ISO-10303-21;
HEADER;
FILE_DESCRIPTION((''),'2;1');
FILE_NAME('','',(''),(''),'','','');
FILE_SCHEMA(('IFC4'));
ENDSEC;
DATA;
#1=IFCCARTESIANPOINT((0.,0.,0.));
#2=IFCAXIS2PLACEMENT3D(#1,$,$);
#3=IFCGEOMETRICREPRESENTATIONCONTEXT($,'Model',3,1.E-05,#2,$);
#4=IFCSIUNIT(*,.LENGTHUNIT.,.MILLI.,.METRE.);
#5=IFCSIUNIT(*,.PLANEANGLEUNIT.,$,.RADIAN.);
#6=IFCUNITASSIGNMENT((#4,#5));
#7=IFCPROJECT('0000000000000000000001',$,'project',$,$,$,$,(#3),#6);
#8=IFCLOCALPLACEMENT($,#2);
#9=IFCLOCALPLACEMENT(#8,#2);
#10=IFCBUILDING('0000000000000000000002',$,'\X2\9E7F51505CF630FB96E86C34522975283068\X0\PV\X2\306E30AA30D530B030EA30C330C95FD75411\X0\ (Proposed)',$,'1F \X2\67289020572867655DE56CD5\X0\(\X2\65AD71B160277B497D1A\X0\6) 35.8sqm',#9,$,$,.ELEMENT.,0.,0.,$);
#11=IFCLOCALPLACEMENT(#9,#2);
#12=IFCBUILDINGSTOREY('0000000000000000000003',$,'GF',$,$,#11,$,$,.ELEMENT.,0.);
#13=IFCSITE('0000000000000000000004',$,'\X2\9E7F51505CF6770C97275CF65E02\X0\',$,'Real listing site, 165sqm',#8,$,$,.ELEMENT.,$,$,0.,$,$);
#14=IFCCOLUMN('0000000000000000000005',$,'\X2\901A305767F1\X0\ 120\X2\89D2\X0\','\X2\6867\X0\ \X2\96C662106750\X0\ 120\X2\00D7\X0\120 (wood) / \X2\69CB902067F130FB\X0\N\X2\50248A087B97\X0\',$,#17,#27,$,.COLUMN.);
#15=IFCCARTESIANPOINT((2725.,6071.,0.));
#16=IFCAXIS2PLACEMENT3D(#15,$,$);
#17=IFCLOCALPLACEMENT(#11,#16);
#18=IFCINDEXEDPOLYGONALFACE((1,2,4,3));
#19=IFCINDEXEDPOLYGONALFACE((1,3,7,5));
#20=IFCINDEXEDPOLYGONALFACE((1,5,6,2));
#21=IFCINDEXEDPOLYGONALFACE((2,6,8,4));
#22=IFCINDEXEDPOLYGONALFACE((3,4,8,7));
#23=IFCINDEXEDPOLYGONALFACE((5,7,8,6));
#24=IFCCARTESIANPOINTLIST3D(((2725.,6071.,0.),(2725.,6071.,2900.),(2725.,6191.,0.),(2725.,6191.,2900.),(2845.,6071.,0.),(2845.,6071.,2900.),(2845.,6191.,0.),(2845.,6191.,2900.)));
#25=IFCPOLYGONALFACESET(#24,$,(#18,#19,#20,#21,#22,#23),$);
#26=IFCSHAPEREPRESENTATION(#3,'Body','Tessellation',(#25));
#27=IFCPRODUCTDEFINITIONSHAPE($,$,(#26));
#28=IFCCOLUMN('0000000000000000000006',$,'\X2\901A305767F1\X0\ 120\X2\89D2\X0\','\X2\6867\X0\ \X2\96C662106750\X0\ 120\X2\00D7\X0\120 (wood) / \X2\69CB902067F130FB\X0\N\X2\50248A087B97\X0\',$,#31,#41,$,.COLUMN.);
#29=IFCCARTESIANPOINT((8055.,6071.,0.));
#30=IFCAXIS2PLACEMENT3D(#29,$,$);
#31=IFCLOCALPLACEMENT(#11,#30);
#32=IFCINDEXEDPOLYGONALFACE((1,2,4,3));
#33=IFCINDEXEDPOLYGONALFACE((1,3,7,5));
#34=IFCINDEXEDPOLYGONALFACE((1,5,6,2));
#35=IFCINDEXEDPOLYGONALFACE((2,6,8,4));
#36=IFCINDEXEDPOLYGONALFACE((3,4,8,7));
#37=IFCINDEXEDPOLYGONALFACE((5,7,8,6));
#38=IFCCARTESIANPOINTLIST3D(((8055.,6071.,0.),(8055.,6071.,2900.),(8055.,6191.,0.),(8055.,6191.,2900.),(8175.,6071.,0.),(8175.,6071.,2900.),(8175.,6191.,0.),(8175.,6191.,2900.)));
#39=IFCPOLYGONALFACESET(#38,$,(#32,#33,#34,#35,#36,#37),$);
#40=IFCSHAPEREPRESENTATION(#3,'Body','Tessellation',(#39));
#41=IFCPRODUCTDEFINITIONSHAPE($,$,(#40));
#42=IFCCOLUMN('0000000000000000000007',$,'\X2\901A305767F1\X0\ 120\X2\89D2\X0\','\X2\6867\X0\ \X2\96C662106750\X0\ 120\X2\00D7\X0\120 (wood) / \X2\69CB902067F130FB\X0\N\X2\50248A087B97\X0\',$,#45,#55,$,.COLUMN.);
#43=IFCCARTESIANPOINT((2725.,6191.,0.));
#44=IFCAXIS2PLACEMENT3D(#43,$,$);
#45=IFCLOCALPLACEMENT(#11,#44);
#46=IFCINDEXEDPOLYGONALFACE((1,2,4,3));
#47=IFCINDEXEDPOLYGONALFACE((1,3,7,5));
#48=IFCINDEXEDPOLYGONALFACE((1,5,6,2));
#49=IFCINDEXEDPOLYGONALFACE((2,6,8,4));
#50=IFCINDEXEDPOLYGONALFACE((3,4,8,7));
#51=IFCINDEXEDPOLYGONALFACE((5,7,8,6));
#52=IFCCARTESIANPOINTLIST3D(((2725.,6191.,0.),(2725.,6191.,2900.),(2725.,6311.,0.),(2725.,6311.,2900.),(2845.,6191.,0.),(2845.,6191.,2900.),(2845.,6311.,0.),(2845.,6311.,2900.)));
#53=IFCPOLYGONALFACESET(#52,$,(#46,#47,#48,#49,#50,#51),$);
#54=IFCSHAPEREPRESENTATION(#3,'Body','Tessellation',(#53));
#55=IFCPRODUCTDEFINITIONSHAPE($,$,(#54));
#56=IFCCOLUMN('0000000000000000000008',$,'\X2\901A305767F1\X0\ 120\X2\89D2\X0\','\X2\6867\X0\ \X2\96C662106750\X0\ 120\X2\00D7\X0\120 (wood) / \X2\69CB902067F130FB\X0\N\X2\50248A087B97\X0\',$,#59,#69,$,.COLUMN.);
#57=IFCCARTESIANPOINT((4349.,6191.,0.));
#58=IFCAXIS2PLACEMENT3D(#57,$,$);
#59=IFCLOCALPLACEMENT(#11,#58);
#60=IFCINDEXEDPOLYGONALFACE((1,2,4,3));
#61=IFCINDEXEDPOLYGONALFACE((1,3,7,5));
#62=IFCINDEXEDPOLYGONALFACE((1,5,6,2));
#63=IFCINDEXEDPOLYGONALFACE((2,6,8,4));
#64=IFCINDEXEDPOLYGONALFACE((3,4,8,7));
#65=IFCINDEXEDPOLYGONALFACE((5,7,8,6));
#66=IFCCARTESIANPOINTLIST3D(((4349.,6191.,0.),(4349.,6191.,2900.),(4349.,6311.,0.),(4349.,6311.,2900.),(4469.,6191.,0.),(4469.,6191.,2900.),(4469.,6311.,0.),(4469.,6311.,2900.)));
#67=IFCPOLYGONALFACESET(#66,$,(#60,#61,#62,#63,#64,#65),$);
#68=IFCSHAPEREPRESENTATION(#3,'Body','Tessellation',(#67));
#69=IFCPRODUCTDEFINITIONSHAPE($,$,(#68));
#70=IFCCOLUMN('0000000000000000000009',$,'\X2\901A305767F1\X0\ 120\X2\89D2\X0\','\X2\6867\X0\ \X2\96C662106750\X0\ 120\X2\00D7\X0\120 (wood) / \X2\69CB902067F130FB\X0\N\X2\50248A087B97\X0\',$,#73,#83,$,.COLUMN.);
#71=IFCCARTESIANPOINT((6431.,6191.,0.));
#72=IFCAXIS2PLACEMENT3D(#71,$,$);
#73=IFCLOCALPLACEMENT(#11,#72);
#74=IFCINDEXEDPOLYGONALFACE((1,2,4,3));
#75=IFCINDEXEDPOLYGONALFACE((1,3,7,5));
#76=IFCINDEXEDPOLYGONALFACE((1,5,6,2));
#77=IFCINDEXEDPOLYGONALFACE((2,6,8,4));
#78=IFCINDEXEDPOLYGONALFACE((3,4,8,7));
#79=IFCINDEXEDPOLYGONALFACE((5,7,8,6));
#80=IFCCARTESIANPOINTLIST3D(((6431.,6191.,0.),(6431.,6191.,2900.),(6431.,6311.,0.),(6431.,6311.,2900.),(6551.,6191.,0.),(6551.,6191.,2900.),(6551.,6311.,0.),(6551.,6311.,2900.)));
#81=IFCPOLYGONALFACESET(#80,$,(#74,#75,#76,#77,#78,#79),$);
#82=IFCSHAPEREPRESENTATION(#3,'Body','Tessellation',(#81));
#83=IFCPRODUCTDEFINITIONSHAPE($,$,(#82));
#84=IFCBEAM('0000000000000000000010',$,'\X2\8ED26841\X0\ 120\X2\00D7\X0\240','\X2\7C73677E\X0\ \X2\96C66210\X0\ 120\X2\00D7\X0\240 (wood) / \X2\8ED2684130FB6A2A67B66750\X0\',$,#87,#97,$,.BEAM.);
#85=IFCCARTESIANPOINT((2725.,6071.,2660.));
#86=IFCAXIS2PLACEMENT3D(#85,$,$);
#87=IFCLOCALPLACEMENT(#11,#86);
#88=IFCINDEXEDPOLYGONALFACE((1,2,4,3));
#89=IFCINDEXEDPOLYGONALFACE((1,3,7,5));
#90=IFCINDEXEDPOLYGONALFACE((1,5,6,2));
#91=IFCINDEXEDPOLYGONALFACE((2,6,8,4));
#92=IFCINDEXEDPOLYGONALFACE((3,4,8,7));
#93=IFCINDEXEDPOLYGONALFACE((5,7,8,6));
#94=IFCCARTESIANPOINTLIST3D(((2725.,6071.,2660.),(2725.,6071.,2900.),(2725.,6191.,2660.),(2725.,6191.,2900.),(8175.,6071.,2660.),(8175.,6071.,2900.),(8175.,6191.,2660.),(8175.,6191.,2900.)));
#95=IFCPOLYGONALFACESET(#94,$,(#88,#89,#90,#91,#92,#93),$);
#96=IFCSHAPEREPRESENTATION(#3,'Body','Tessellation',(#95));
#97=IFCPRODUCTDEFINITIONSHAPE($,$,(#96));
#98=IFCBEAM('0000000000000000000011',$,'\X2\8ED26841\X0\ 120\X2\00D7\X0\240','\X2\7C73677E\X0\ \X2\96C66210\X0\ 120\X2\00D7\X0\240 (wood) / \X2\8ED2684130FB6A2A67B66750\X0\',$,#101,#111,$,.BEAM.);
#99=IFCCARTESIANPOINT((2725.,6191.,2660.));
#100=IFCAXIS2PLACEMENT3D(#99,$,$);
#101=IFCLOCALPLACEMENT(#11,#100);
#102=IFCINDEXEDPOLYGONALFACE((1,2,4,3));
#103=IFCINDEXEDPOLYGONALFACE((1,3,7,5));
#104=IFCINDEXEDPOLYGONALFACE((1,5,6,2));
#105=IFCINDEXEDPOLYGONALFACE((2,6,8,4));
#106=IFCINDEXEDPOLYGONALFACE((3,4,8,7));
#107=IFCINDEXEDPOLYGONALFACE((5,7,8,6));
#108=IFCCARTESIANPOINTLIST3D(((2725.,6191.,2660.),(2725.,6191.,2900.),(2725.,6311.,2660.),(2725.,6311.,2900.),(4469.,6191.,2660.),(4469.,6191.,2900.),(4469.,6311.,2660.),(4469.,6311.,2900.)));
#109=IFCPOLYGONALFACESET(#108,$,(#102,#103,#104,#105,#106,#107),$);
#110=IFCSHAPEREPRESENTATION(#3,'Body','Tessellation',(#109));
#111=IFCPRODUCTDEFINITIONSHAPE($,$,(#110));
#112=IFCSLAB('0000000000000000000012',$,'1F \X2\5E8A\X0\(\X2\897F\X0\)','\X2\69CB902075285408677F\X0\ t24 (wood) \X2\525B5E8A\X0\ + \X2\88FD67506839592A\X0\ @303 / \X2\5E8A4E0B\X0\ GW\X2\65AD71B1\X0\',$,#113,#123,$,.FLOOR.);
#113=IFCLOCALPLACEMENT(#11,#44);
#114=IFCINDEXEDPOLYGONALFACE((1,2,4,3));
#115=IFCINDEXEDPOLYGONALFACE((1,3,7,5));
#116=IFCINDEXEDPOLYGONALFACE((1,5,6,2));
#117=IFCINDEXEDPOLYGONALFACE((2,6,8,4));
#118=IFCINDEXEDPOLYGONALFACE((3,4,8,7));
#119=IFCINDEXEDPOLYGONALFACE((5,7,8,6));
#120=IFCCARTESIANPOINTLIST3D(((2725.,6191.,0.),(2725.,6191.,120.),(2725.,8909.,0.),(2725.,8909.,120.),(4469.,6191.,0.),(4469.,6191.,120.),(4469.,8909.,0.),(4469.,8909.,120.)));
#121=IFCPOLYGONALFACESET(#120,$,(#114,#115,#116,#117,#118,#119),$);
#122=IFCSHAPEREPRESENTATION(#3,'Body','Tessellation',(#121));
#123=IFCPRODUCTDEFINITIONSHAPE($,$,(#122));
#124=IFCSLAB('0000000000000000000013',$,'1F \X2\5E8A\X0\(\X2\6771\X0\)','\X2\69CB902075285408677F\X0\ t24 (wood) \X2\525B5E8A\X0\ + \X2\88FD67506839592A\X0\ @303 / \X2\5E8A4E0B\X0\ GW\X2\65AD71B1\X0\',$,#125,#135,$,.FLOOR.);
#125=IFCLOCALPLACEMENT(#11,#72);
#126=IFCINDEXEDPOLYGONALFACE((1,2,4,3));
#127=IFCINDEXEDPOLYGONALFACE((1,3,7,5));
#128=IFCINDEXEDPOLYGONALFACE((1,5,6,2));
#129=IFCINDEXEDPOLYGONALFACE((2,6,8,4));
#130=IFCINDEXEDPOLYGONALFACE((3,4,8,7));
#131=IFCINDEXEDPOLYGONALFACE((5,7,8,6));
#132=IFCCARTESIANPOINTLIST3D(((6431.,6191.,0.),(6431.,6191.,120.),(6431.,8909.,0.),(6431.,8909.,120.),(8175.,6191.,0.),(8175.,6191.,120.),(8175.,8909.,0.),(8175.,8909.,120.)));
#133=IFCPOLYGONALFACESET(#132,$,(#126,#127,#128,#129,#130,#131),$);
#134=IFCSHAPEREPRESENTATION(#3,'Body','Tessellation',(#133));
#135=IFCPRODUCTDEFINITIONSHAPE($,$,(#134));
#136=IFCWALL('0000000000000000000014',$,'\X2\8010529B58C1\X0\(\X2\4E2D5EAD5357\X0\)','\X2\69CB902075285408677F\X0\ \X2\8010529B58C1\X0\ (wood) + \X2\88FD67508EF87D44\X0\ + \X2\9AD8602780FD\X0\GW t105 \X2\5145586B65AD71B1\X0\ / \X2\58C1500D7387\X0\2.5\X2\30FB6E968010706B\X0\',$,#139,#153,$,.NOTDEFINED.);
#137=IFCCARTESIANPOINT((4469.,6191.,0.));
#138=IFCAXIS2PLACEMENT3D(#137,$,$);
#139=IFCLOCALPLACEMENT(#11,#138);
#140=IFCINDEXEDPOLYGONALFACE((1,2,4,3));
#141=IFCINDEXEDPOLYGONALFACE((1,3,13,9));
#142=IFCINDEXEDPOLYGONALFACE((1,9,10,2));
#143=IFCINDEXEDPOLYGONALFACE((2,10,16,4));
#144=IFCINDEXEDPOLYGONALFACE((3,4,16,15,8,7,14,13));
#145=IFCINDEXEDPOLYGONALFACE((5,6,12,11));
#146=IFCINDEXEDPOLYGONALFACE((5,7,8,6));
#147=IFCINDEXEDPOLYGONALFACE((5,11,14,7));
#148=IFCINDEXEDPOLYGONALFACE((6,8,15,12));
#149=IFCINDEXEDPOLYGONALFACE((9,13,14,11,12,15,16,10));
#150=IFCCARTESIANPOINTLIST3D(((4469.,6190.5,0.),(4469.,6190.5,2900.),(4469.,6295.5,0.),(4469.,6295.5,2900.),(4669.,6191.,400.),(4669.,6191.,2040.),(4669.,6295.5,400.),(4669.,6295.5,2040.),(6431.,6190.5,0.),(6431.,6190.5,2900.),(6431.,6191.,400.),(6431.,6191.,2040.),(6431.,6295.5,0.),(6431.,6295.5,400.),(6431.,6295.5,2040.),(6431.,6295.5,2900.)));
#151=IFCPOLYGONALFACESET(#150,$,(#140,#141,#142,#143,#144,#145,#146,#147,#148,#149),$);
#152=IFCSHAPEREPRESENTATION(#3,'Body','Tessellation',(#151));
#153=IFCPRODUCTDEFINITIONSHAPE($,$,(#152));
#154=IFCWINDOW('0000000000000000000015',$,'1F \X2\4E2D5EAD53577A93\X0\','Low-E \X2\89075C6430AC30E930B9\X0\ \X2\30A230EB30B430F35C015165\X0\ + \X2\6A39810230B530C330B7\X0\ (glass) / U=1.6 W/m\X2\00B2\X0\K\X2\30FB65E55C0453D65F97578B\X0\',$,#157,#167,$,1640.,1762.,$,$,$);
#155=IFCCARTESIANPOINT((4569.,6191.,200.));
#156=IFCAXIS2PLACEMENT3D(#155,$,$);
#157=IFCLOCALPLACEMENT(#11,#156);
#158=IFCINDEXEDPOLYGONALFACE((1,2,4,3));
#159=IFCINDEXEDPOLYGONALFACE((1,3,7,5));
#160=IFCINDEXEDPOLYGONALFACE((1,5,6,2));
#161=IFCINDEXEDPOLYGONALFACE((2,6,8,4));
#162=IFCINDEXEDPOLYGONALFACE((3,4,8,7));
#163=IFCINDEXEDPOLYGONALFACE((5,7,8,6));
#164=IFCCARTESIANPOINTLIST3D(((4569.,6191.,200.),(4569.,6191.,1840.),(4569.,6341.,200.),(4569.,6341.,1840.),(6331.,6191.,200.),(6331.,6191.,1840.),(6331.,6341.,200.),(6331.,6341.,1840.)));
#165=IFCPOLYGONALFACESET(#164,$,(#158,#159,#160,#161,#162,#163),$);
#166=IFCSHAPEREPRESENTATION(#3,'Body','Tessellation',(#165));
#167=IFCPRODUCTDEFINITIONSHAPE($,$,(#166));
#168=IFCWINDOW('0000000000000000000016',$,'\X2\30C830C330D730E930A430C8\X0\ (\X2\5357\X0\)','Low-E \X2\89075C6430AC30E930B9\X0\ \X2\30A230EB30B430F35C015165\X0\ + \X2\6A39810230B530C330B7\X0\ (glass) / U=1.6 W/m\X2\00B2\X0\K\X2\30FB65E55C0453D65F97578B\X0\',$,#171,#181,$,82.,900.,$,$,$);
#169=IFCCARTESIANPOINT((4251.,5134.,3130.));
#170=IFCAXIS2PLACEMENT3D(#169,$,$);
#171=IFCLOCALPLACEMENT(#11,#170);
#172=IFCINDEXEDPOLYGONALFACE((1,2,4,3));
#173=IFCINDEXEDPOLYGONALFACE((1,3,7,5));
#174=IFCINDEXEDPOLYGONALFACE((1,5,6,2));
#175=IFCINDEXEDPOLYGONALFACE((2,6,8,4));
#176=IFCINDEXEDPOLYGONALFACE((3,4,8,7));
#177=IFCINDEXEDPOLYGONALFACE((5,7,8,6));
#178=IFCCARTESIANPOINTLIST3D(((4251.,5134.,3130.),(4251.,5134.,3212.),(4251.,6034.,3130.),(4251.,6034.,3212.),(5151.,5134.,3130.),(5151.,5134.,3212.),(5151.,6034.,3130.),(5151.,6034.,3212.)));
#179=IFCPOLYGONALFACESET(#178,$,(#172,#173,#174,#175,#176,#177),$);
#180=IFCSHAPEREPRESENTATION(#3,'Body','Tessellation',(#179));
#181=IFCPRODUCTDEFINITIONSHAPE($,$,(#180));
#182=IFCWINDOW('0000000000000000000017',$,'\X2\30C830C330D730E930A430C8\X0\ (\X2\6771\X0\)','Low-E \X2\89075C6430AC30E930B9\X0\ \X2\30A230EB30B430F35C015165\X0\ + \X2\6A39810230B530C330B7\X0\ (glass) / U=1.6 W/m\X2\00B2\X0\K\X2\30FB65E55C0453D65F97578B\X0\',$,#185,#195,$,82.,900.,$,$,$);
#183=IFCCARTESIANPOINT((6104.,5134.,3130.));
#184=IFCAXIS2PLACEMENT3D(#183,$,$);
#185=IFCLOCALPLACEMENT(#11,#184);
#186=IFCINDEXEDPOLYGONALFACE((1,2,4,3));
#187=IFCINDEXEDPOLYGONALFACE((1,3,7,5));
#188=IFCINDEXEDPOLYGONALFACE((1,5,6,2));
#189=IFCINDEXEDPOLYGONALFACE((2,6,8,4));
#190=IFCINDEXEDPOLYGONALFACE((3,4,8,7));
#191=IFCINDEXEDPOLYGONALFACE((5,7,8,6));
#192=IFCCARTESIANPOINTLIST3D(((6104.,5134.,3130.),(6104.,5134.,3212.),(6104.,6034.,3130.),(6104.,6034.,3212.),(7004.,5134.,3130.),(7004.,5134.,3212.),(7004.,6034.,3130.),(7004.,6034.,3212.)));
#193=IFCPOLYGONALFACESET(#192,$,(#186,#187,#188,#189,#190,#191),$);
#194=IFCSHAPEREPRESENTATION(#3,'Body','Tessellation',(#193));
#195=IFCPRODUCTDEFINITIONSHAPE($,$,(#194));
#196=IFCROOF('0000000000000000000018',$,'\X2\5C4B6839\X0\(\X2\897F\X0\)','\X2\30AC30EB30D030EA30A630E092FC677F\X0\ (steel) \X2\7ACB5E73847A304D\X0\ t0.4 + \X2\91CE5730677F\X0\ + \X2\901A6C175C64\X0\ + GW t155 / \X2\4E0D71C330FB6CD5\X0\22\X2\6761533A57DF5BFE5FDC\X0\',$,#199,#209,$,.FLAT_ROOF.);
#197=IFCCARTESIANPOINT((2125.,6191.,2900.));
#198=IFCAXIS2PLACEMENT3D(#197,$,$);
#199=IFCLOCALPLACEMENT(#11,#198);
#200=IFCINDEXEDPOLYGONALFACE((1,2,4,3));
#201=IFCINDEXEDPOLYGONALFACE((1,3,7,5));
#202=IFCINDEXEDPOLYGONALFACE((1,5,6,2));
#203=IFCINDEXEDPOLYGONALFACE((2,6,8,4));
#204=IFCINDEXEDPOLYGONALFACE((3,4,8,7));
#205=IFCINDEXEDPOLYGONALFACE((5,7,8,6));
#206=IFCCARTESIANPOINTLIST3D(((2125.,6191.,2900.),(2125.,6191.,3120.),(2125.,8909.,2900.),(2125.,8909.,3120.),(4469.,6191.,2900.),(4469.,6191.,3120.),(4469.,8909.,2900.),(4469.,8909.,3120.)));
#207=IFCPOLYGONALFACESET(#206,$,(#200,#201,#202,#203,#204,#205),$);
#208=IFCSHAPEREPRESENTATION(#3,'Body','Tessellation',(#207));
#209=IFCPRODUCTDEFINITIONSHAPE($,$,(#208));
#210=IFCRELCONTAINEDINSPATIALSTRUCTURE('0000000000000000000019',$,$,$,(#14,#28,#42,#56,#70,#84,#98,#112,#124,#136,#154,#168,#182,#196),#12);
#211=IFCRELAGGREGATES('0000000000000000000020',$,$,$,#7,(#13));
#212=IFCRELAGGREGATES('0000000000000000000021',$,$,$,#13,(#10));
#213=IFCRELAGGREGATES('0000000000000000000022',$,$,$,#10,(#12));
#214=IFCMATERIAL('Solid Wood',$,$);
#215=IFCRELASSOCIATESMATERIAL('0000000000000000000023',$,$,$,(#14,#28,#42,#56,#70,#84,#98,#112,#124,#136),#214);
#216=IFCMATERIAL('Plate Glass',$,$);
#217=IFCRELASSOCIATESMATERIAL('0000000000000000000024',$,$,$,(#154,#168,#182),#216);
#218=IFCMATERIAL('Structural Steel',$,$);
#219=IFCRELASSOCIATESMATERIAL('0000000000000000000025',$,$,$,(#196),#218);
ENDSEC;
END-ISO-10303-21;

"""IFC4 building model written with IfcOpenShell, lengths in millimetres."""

from ifc_helpers import new_model, si_unit, frame, frame_2d, origin, place, context, project, spatial, rectangle, extrude, material, element, fill, save


model = new_model("IFC4")

# Units and contexts
model_context = context("Model", 3, precision=1e-05, world=origin())
ifc_project = project(units=[si_unit("LENGTHUNIT", "METRE", prefix="MILLI"), si_unit("PLANEANGLEUNIT", "RADIAN")], contexts=[model_context])

# Site, building, storey
site_placement = place(None, origin())
site = spatial("IfcSite", under=ifc_project, at=site_placement, Name="鹿児島県霧島市", ObjectType="Real listing site, 165sqm", CompositionType="ELEMENT", RefElevation=0.0)
building_placement = place(site_placement, origin())
building = spatial("IfcBuilding", under=site, at=building_placement, Name="鹿児島・雨水利用とPVのオフグリッド志向 (Proposed)", ObjectType="1F 木造在来工法(断熱性等級6) 35.8sqm", CompositionType="ELEMENT", ElevationOfRefHeight=0.0, ElevationOfTerrain=0.0)
storey_placement = place(building_placement, origin())
storey = spatial("IfcBuildingStorey", under=building, at=storey_placement, Name="GF", CompositionType="ELEMENT", Elevation=0.0)

# Columns
ifc_material_1 = material(Name="Solid Wood")
column_1_placement = place(storey_placement, frame((2725.0, 6071.0, 0.0)))
element("IfcColumn", 1, at=column_1_placement, inside=storey, material=ifc_material_1, Name="通し柱 120角", Description="桧 集成材 120×120 (wood) / 構造柱・N値計算", PredefinedType="COLUMN", context=model_context, shape_type="SweptSolid", body=[
    extrude(rectangle(XDim=120.0, YDim=120.0, at=frame_2d((60.0, 60.0))), frame((2725.0, 6071.0, 0.0)), (0.0, 0.0, 1.0), 2900.0),
])
column_2_placement = place(storey_placement, frame((8055.0, 6071.0, 0.0)))
element("IfcColumn", 2, at=column_2_placement, inside=storey, material=ifc_material_1, Name="通し柱 120角", Description="桧 集成材 120×120 (wood) / 構造柱・N値計算", PredefinedType="COLUMN", context=model_context, shape_type="SweptSolid", body=[
    extrude(rectangle(XDim=120.0, YDim=120.0, at=frame_2d((60.0, 60.0))), frame((8055.0, 6071.0, 0.0)), (0.0, 0.0, 1.0), 2900.0),
])
column_3_placement = place(storey_placement, frame((2725.0, 6191.0, 0.0)))
element("IfcColumn", 3, at=column_3_placement, inside=storey, material=ifc_material_1, Name="通し柱 120角", Description="桧 集成材 120×120 (wood) / 構造柱・N値計算", PredefinedType="COLUMN", context=model_context, shape_type="SweptSolid", body=[
    extrude(rectangle(XDim=120.0, YDim=120.0, at=frame_2d((60.0, 60.0))), frame((2725.0, 6191.0, 0.0)), (0.0, 0.0, 1.0), 2900.0),
])
column_4_placement = place(storey_placement, frame((4349.0, 6191.0, 0.0)))
element("IfcColumn", 4, at=column_4_placement, inside=storey, material=ifc_material_1, Name="通し柱 120角", Description="桧 集成材 120×120 (wood) / 構造柱・N値計算", PredefinedType="COLUMN", context=model_context, shape_type="SweptSolid", body=[
    extrude(rectangle(XDim=120.0, YDim=120.0, at=frame_2d((60.0, 60.0))), frame((4349.0, 6191.0, 0.0)), (0.0, 0.0, 1.0), 2900.0),
])
column_5_placement = place(storey_placement, frame((6431.0, 6191.0, 0.0)))
element("IfcColumn", 5, at=column_5_placement, inside=storey, material=ifc_material_1, Name="通し柱 120角", Description="桧 集成材 120×120 (wood) / 構造柱・N値計算", PredefinedType="COLUMN", context=model_context, shape_type="SweptSolid", body=[
    extrude(rectangle(XDim=120.0, YDim=120.0, at=frame_2d((60.0, 60.0))), frame((6431.0, 6191.0, 0.0)), (0.0, 0.0, 1.0), 2900.0),
])

# Beams
beam_1_placement = place(storey_placement, frame((2725.0, 6071.0, 2660.0)))
element("IfcBeam", 6, at=beam_1_placement, inside=storey, material=ifc_material_1, Name="軒桁 120×240", Description="米松 集成 120×240 (wood) / 軒桁・横架材", PredefinedType="BEAM", context=model_context, shape_type="SweptSolid", body=[
    extrude(rectangle(XDim=5450.0, YDim=120.0, at=frame_2d((2725.0, 60.0))), frame((2725.0, 6071.0, 2660.0)), (0.0, 0.0, 1.0), 240.0),
])
beam_2_placement = place(storey_placement, frame((2725.0, 6191.0, 2660.0)))
element("IfcBeam", 7, at=beam_2_placement, inside=storey, material=ifc_material_1, Name="軒桁 120×240", Description="米松 集成 120×240 (wood) / 軒桁・横架材", PredefinedType="BEAM", context=model_context, shape_type="SweptSolid", body=[
    extrude(rectangle(XDim=1744.0, YDim=120.0, at=frame_2d((872.0, 60.0))), frame((2725.0, 6191.0, 2660.0)), (0.0, 0.0, 1.0), 240.0),
])

# Slabs
slab_1_placement = place(storey_placement, frame((2725.0, 6191.0, 0.0)))
element("IfcSlab", 8, at=slab_1_placement, inside=storey, material=ifc_material_1, Name="1F 床(西)", Description="構造用合板 t24 (wood) 剛床 + 製材根太 @303 / 床下 GW断熱", PredefinedType="FLOOR", context=model_context, shape_type="SweptSolid", body=[
    extrude(rectangle(XDim=1744.0, YDim=2718.0, at=frame_2d((872.0, 1359.0))), frame((2725.0, 6191.0, 0.0)), (0.0, 0.0, 1.0), 120.0),
])
slab_2_placement = place(storey_placement, frame((6431.0, 6191.0, 0.0)))
element("IfcSlab", 9, at=slab_2_placement, inside=storey, material=ifc_material_1, Name="1F 床(東)", Description="構造用合板 t24 (wood) 剛床 + 製材根太 @303 / 床下 GW断熱", PredefinedType="FLOOR", context=model_context, shape_type="SweptSolid", body=[
    extrude(rectangle(XDim=1744.0, YDim=2718.0, at=frame_2d((872.0, 1359.0))), frame((6431.0, 6191.0, 0.0)), (0.0, 0.0, 1.0), 120.0),
])

# Wall, opening, window
wall_1_placement = place(storey_placement, frame((4469.0, 6191.0, 0.0)))
wall_1 = element("IfcWall", 10, at=wall_1_placement, inside=storey, material=ifc_material_1, Name="耐力壁(中庭南)", Description="構造用合板 耐力壁 (wood) + 製材軸組 + 高性能GW t105 充填断熱 / 壁倍率2.5・準耐火", PredefinedType="NOTDEFINED", context=model_context, shape_type="SweptSolid", body=[
    extrude(rectangle(XDim=1962.0, YDim=105.0, at=frame_2d((981.0, 52.0))), frame((4469.0, 6191.0, 0.0)), (0.0, 0.0, 1.0), 2900.0),
])
opening_placement = place(storey_placement, frame((4569.0, 6191.0, 200.0)))
opening = element("IfcOpeningElement", 11, at=opening_placement, cuts=wall_1, PredefinedType="NOTDEFINED", context=model_context, shape_type="SweptSolid", body=[
    extrude(rectangle(XDim=1762.0, YDim=150.0, at=frame_2d((881.0, 75.0))), frame((4569.0, 6191.0, 200.0)), (0.0, 0.0, 1.0), 1640.0),
])
ifc_material_2 = material(Name="Plate Glass")
window_1_placement = place(storey_placement, frame((4569.0, 6191.0, 200.0)))
window_1 = element("IfcWindow", 12, at=window_1_placement, inside=storey, material=ifc_material_2, Name="1F 中庭南窓", Description="Low-E 複層ガラス アルゴン封入 + 樹脂サッシ (glass) / U=1.6 W/m²K・日射取得型", OverallHeight=1640.0, OverallWidth=1762.0, context=model_context, shape_type="SweptSolid", body=[
    extrude(rectangle(XDim=1762.0, YDim=150.0, at=frame_2d((881.0, 75.0))), frame((4569.0, 6191.0, 200.0)), (0.0, 0.0, 1.0), 1640.0),
])
fill(opening, window_1)

# Windows
window_2_placement = place(storey_placement, frame((4251.0, 5134.0, 3130.0)))
element("IfcWindow", 13, at=window_2_placement, inside=storey, material=ifc_material_2, Name="トップライト (南)", Description="Low-E 複層ガラス アルゴン封入 + 樹脂サッシ (glass) / U=1.6 W/m²K・日射取得型", OverallHeight=82.0, OverallWidth=900.0, context=model_context, shape_type="SweptSolid", body=[
    extrude(rectangle(XDim=900.0, YDim=900.0, at=frame_2d((450.0, 450.0))), frame((4251.0, 5134.0, 3130.0)), (0.0, 0.0, 1.0), 82.0),
])
window_3_placement = place(storey_placement, frame((6104.0, 5134.0, 3130.0)))
element("IfcWindow", 14, at=window_3_placement, inside=storey, material=ifc_material_2, Name="トップライト (東)", Description="Low-E 複層ガラス アルゴン封入 + 樹脂サッシ (glass) / U=1.6 W/m²K・日射取得型", OverallHeight=82.0, OverallWidth=900.0, context=model_context, shape_type="SweptSolid", body=[
    extrude(rectangle(XDim=900.0, YDim=900.0, at=frame_2d((450.0, 450.0))), frame((6104.0, 5134.0, 3130.0)), (0.0, 0.0, 1.0), 82.0),
])

# Roof
ifc_material_3 = material(Name="Structural Steel")
roof_1_placement = place(storey_placement, frame((2125.0, 6191.0, 2900.0)))
element("IfcRoof", 15, at=roof_1_placement, inside=storey, material=ifc_material_3, Name="屋根(西)", Description="ガルバリウム鋼板 (steel) 立平葺き t0.4 + 野地板 + 通気層 + GW t155 / 不燃・法22条区域対応", PredefinedType="FLAT_ROOF", context=model_context, shape_type="SweptSolid", body=[
    extrude(rectangle(XDim=2344.0, YDim=2718.0, at=frame_2d((1172.0, 1359.0))), frame((2125.0, 6191.0, 2900.0)), (0.0, 0.0, 1.0), 220.0),
])

save(model, "model.ifc")
